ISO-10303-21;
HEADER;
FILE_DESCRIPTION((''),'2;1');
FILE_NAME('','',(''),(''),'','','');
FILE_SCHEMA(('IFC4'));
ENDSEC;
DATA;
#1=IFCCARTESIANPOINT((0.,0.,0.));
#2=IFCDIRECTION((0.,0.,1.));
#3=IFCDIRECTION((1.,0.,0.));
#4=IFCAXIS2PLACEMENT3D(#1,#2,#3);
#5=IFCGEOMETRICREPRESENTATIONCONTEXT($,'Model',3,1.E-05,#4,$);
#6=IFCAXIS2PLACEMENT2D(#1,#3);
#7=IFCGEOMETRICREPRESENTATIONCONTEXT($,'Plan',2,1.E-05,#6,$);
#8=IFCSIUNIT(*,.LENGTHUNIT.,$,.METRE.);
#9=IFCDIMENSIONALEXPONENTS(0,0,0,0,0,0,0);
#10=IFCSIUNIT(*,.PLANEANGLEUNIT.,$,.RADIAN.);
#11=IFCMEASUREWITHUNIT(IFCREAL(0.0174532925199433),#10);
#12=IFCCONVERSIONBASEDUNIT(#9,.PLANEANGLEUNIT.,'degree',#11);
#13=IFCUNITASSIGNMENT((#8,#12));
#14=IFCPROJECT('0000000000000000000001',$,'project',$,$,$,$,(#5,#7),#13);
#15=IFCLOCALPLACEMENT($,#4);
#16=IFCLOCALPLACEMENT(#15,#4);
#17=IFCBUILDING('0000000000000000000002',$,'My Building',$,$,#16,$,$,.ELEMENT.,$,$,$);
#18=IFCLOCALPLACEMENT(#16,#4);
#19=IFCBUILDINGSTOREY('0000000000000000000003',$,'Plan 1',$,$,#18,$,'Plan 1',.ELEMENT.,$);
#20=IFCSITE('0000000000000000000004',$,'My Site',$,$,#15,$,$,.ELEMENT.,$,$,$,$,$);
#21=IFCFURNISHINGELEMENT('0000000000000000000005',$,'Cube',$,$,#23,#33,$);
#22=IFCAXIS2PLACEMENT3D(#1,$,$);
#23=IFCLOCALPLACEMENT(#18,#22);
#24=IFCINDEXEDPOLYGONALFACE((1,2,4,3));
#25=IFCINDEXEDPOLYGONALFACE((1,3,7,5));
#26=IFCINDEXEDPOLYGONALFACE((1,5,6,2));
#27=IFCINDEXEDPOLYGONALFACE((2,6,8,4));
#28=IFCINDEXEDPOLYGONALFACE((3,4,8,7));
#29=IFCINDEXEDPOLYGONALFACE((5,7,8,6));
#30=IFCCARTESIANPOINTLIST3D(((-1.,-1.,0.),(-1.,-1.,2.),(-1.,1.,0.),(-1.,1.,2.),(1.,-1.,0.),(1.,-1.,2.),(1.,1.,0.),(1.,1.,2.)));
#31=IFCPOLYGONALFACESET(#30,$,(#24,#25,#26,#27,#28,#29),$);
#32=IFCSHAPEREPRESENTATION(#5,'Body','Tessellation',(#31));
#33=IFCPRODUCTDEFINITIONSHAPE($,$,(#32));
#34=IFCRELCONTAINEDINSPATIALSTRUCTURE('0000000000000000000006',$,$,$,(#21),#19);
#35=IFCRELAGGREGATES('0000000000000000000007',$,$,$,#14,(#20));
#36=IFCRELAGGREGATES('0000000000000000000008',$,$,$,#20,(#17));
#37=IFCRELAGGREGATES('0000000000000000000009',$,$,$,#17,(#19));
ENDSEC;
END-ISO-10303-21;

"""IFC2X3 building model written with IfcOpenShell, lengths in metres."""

from ifc_helpers import new_model, entity, si_unit, converted_unit, frame, frame_2d, origin_with_axes, place, context, project, spatial, rectangle, extrude, shape, element, save


model = new_model("IFC2X3")

# Units and contexts
model_context = context("Model", 3, precision=1e-05, world=origin_with_axes())
plan_context = context("Plan", 2, precision=1e-05, world=frame_2d((0.0, 0.0, 0.0), x_axis=(1.0, 0.0, 0.0)))
ifc_project = project(units=[si_unit("LENGTHUNIT", "METRE"), converted_unit("PLANEANGLEUNIT", "degree", entity("IfcReal", 0.0174532925199433), si_unit("PLANEANGLEUNIT", "RADIAN"), dimensions=[0, 0, 0, 0, 0, 0, 0])], contexts=[model_context, plan_context])

# Site, building, storey
site_placement = place(None, origin_with_axes())
site = spatial("IfcSite", under=ifc_project, at=site_placement, Name="My Site", CompositionType="ELEMENT")
building_placement = place(site_placement, origin_with_axes())
building = spatial("IfcBuilding", under=site, at=building_placement, Name="My Building", CompositionType="ELEMENT")
storey_placement = place(building_placement, origin_with_axes())
storey = spatial("IfcBuildingStorey", under=building, at=storey_placement, Name="Plan 1", LongName="Plan 1", CompositionType="ELEMENT")

# Furnishing element
furnishing_placement = place(storey_placement, origin_with_axes())
element("IfcFurnishingElement", 1, at=furnishing_placement, inside=storey, Name="Cube", shapes=[
    shape(model_context, None, "SweptSolid", [extrude(rectangle(XDim=2.0, YDim=2.0, at=frame_2d((0.0, 0.0, 0.0))), frame((0.0, 0.0, 0.0), z_axis=(0.0, 0.0, -1.0), x_axis=(-1.0, 0.0, 0.0)), (0.0, 0.0, -1.0), 2.0)]),
])

save(model, "model.ifc")
